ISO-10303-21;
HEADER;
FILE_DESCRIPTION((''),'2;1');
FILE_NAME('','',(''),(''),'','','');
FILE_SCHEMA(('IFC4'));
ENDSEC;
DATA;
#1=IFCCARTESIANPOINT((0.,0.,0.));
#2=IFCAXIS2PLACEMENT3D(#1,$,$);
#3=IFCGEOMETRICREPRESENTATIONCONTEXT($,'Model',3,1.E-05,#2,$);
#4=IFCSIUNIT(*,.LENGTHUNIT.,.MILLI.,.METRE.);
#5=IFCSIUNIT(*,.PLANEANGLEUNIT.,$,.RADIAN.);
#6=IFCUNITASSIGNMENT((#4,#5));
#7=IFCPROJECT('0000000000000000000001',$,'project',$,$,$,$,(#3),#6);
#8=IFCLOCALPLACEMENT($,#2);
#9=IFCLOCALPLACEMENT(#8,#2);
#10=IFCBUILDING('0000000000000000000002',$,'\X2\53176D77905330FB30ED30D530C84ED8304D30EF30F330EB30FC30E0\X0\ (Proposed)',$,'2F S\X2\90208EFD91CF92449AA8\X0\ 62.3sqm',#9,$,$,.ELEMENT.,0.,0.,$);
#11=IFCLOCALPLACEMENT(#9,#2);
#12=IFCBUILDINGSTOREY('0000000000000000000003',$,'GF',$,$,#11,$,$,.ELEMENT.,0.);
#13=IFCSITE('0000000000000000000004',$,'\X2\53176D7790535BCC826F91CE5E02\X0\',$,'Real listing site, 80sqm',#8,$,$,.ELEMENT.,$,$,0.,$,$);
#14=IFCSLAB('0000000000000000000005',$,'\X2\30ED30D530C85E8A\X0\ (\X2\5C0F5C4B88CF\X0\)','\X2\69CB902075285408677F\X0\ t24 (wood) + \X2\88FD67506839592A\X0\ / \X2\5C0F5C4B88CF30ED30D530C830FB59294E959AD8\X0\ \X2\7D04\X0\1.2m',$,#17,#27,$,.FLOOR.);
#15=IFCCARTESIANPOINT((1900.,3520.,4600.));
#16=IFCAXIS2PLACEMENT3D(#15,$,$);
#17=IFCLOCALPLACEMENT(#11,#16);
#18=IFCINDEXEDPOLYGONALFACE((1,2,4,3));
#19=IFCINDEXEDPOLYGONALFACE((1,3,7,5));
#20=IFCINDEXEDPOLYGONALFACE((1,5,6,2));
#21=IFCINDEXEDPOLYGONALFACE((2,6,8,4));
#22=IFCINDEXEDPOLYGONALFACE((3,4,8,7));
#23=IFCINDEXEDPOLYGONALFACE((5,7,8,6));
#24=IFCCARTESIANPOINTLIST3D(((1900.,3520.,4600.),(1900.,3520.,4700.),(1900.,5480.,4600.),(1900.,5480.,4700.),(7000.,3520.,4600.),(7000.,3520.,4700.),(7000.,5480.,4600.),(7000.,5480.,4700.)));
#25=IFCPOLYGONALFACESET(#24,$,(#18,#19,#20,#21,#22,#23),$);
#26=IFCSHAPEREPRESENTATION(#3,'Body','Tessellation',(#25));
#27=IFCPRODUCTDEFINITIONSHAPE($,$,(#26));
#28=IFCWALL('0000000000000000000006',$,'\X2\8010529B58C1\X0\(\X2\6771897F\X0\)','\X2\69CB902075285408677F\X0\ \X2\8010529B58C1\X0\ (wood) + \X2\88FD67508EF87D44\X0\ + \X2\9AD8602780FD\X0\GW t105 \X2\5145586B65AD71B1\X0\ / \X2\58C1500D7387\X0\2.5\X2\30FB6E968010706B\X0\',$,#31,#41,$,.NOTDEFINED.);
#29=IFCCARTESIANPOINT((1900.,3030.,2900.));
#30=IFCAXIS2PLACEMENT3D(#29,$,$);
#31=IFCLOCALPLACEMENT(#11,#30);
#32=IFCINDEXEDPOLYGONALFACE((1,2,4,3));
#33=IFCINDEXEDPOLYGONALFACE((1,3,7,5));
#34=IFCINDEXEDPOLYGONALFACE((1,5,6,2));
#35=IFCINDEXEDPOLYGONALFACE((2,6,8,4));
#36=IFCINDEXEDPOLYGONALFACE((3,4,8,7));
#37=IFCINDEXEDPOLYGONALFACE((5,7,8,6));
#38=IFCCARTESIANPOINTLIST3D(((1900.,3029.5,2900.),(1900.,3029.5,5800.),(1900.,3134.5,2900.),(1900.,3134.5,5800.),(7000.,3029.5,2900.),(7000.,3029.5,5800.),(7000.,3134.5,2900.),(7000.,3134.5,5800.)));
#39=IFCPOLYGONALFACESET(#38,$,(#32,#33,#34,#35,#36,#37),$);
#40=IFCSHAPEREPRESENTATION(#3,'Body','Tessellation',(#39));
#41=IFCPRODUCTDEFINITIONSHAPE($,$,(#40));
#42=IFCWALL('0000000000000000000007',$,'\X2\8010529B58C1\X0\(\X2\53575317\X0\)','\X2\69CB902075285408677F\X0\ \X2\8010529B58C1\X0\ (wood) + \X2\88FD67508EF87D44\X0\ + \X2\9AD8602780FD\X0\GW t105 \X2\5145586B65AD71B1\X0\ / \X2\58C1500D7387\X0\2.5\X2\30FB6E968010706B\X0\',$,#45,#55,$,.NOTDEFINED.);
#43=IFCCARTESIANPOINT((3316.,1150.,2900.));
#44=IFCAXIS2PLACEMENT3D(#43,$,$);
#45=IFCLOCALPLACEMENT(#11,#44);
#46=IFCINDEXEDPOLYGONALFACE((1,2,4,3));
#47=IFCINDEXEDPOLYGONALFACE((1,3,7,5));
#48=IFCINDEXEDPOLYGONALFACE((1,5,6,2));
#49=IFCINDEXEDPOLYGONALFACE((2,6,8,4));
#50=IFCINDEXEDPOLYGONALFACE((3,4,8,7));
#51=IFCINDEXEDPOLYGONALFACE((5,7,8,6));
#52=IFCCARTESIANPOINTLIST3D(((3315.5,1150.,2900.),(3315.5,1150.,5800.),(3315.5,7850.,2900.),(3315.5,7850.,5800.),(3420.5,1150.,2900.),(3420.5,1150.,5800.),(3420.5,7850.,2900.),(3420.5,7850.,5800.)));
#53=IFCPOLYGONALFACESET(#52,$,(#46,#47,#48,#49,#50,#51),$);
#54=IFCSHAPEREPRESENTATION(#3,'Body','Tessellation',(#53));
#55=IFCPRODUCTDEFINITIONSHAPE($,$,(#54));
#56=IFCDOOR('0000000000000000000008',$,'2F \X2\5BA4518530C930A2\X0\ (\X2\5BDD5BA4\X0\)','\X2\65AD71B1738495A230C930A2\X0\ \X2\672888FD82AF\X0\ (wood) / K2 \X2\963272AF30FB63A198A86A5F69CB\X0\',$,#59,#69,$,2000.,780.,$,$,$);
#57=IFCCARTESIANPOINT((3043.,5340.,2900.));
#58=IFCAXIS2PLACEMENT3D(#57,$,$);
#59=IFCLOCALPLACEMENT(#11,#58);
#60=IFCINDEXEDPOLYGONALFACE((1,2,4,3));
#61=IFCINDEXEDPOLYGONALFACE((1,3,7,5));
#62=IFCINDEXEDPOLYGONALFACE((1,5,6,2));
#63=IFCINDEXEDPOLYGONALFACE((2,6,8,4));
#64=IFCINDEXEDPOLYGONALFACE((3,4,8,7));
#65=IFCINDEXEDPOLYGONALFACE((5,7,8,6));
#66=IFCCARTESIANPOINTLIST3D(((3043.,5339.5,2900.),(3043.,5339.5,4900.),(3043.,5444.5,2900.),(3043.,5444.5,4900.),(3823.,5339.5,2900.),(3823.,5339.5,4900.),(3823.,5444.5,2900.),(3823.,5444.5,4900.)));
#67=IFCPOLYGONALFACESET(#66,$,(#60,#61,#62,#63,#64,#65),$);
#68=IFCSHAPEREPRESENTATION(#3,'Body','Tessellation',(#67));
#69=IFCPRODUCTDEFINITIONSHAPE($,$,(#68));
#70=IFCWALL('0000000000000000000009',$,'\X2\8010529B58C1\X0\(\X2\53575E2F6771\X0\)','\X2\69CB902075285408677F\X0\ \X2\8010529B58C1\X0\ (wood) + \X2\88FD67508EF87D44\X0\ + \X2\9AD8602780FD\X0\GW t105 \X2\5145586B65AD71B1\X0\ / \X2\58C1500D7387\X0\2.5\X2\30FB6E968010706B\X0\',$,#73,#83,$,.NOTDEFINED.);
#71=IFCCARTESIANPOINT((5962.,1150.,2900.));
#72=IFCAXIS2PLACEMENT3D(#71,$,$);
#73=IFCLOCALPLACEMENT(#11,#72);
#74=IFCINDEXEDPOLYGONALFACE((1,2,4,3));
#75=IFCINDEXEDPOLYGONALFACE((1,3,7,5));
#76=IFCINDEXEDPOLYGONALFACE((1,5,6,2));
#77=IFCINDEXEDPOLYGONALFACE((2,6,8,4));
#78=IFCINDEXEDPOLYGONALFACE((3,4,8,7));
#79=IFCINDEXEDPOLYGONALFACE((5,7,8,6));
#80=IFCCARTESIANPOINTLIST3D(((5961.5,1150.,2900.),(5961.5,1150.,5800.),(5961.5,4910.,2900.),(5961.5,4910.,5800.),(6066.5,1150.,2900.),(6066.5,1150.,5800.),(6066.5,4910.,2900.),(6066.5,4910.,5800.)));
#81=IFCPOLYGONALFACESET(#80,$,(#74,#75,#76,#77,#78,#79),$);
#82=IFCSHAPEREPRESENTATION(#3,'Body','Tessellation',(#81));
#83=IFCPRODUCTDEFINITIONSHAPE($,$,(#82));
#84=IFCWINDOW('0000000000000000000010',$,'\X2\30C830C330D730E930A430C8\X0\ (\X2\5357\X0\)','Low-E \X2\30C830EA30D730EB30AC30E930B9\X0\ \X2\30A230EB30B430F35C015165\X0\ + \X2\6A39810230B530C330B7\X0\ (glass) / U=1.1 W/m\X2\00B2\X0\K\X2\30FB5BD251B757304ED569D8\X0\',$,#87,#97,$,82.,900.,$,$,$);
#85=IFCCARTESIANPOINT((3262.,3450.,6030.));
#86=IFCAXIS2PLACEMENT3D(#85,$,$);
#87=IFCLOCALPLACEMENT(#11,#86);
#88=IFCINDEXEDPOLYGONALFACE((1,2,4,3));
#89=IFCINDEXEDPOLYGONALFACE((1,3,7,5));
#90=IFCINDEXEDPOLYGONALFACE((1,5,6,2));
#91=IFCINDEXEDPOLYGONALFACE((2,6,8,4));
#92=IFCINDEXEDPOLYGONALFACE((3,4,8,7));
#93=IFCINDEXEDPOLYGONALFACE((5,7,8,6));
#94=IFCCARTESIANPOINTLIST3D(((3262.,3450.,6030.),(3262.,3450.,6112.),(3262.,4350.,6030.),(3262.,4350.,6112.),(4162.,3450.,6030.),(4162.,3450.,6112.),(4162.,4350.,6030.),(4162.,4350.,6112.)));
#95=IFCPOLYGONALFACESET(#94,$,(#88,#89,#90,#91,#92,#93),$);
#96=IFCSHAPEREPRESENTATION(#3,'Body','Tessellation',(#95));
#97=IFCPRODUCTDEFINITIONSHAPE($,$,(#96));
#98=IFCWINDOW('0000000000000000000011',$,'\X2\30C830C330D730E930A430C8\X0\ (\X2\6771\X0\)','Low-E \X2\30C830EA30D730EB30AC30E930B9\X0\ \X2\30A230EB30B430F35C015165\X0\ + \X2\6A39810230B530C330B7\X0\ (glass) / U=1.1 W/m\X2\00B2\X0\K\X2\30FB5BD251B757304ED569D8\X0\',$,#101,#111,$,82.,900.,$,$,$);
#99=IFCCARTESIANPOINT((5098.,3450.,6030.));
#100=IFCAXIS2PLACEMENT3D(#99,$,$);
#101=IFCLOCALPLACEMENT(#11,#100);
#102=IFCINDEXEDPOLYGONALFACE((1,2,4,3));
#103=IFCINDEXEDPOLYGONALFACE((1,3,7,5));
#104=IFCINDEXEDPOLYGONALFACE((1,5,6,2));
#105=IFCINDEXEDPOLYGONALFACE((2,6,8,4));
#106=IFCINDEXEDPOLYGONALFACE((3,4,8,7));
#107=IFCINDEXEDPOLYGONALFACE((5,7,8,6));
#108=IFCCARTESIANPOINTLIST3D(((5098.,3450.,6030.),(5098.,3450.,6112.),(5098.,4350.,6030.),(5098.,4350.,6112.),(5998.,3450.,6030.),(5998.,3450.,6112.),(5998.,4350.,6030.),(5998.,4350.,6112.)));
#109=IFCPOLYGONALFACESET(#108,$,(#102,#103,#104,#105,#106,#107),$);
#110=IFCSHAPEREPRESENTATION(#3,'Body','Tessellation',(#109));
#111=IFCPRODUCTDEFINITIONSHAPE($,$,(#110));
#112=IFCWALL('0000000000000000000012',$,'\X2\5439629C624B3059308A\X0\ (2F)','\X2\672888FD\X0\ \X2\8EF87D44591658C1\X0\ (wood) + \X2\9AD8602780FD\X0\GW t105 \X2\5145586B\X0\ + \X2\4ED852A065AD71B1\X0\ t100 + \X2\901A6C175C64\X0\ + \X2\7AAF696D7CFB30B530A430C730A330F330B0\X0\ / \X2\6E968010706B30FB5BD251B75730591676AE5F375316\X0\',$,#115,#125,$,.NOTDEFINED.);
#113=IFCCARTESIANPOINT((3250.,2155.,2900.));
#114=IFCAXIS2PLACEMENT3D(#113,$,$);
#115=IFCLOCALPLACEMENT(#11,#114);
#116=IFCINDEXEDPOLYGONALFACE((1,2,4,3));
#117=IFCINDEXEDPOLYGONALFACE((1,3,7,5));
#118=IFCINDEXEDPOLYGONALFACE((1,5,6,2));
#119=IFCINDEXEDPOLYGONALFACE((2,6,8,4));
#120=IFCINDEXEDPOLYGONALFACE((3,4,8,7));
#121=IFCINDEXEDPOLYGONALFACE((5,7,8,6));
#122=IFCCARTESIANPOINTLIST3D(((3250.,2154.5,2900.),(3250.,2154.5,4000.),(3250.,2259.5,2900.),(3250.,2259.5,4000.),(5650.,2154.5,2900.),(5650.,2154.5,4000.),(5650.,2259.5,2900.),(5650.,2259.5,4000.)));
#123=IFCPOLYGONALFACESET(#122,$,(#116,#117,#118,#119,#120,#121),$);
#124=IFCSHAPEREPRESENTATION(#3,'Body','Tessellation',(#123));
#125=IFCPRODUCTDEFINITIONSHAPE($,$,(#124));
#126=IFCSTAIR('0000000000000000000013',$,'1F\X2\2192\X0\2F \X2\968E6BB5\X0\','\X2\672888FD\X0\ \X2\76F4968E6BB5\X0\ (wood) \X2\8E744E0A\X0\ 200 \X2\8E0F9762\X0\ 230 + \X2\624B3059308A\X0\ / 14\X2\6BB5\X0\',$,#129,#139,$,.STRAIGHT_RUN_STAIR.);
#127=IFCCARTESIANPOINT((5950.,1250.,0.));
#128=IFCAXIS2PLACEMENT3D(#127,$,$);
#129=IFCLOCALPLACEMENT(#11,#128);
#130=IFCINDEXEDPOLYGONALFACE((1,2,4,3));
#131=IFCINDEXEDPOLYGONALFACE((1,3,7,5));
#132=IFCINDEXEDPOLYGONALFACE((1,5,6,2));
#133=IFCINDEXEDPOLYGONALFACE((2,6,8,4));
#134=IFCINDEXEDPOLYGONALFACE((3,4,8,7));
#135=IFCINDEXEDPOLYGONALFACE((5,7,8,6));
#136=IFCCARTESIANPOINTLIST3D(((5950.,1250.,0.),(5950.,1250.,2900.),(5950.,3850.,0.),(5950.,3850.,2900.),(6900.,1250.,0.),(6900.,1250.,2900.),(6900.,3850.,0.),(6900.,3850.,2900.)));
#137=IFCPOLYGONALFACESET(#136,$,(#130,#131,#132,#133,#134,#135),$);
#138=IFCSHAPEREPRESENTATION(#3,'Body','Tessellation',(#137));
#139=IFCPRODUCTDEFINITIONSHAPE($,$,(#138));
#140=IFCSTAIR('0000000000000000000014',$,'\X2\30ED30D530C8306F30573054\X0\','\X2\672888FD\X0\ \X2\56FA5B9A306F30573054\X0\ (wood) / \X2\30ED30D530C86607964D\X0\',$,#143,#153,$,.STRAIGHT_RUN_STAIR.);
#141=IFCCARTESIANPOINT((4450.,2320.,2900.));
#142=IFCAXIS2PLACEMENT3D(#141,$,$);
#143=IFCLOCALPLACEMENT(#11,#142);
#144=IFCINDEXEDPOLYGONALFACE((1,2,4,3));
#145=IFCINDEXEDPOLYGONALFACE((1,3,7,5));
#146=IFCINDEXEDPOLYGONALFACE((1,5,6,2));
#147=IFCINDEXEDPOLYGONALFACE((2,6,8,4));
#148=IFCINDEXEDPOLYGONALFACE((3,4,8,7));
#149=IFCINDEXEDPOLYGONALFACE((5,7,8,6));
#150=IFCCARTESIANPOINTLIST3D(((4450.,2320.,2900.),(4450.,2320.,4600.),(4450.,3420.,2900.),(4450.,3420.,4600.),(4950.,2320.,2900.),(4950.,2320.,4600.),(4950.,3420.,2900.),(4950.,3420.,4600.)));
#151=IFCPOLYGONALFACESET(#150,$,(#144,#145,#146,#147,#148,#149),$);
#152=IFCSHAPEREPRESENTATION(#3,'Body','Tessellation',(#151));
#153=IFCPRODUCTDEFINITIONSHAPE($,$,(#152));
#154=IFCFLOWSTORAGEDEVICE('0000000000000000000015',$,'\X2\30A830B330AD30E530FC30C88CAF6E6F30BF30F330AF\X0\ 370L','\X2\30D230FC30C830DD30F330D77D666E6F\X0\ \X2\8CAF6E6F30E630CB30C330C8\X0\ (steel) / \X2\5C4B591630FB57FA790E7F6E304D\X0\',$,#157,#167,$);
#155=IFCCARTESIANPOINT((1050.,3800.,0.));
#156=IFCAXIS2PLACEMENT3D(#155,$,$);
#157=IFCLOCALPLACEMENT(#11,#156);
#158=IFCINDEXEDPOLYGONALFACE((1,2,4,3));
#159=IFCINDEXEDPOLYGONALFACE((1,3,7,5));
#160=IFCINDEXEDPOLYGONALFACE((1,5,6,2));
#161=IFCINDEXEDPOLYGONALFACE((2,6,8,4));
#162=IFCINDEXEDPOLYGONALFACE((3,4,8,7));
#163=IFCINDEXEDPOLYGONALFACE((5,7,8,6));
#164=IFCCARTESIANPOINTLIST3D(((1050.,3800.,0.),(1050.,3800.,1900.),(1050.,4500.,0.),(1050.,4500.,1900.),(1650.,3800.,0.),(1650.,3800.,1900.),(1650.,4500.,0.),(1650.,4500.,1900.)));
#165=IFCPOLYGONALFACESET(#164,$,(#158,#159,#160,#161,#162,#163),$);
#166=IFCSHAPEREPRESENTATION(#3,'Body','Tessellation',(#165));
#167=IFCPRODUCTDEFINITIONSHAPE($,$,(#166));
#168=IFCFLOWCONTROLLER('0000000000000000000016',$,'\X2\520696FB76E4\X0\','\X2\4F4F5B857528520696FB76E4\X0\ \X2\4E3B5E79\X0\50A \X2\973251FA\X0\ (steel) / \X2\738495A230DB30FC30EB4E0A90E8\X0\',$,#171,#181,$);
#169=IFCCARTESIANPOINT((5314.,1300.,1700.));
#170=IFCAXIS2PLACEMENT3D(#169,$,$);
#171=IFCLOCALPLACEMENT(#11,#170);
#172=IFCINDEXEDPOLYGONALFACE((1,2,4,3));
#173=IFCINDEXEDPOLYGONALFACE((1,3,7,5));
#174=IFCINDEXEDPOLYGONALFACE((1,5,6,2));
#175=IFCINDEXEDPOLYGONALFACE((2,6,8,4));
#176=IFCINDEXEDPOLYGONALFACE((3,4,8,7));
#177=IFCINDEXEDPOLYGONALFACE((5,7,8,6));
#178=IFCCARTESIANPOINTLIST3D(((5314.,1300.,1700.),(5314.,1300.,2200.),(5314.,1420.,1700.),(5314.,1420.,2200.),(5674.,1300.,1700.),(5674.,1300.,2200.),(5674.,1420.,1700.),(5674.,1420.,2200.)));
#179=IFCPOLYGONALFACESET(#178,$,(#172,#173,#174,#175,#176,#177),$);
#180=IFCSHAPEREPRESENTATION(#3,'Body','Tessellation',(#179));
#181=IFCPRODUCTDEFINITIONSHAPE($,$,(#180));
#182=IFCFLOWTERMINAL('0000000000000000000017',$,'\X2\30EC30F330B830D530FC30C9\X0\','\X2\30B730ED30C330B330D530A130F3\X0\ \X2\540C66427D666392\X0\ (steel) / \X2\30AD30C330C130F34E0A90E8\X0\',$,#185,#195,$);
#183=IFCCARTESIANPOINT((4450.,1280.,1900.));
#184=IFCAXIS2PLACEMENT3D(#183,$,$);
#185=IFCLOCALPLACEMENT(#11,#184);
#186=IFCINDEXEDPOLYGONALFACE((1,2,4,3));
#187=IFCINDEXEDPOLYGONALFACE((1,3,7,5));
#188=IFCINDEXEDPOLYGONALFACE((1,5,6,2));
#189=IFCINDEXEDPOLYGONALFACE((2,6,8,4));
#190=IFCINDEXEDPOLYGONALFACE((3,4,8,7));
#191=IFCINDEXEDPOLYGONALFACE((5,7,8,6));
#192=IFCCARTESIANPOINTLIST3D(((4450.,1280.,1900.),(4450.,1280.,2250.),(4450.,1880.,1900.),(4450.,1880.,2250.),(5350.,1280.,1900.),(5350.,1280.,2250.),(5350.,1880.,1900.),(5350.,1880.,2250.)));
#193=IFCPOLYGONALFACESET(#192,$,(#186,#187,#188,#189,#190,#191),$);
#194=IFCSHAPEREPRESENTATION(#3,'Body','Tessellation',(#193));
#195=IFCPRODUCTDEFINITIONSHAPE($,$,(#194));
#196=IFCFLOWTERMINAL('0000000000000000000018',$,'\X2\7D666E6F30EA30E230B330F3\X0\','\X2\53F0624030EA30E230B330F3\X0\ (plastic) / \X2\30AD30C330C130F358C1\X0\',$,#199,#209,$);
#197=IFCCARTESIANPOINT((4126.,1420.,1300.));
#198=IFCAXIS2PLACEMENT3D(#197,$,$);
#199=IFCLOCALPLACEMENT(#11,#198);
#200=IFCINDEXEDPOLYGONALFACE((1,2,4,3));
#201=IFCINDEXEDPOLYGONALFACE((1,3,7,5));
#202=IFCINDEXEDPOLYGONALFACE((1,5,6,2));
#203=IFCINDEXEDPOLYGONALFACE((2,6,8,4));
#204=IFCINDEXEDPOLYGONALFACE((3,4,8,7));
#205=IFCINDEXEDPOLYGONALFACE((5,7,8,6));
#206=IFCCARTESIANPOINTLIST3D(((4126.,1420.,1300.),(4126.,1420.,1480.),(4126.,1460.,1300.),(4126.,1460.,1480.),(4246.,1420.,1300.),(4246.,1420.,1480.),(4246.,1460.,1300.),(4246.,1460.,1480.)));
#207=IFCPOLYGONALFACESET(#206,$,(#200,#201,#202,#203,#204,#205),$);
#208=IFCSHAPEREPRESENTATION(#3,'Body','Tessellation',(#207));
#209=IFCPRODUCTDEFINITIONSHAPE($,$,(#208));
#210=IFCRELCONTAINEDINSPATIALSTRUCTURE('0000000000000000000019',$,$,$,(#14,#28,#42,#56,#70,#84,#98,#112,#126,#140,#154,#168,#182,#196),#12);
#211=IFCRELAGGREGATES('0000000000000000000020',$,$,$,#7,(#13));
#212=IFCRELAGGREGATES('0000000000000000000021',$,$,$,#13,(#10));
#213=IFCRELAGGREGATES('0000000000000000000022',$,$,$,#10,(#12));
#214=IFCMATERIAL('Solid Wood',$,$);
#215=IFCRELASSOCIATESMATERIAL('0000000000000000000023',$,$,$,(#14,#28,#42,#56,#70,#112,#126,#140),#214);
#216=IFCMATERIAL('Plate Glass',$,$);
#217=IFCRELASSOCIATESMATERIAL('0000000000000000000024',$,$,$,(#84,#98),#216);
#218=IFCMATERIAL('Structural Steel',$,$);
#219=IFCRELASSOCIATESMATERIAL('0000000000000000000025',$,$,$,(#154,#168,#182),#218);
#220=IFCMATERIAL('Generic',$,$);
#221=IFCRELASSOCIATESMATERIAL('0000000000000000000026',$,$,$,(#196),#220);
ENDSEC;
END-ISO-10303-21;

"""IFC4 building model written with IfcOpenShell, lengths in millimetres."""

from ifc_helpers import new_model, si_unit, frame, frame_2d, origin, place, context, project, spatial, rectangle, extrude, material, element, fill, save


model = new_model("IFC4")

# Units and contexts
model_context = context("Model", 3, precision=1e-05, world=origin())
ifc_project = project(units=[si_unit("LENGTHUNIT", "METRE", prefix="MILLI"), si_unit("PLANEANGLEUNIT", "RADIAN")], contexts=[model_context])

# Site, building, storey
site_placement = place(None, origin())
site = spatial("IfcSite", under=ifc_project, at=site_placement, Name="北海道富良野市", ObjectType="Real listing site, 80sqm", CompositionType="ELEMENT", RefElevation=0.0)
building_placement = place(site_placement, origin())
building = spatial("IfcBuilding", under=site, at=building_placement, Name="北海道・ロフト付きワンルーム (Proposed)", ObjectType="2F S造軽量鉄骨 62.3sqm", CompositionType="ELEMENT", ElevationOfRefHeight=0.0, ElevationOfTerrain=0.0)
storey_placement = place(building_placement, origin())
storey = spatial("IfcBuildingStorey", under=building, at=storey_placement, Name="GF", CompositionType="ELEMENT", Elevation=0.0)

# Shared definitions
ifc_material_1 = material(Name="Solid Wood")

# Slab
slab_placement = place(storey_placement, frame((1900.0, 3520.0, 4600.0)))
element("IfcSlab", 1, at=slab_placement, inside=storey, material=ifc_material_1, Name="ロフト床 (小屋裏)", Description="構造用合板 t24 (wood) + 製材根太 / 小屋裏ロフト・天井高 約1.2m", PredefinedType="FLOOR", context=model_context, shape_type="SweptSolid", body=[
    extrude(rectangle(XDim=5100.0, YDim=1960.0, at=frame_2d((2550.0, 980.0))), frame((1900.0, 3520.0, 4600.0)), (0.0, 0.0, 1.0), 100.0),
])

# Wall
wall_1_placement = place(storey_placement, frame((1900.0, 3030.0, 2900.0)))
element("IfcWall", 2, at=wall_1_placement, inside=storey, material=ifc_material_1, Name="耐力壁(東西)", Description="構造用合板 耐力壁 (wood) + 製材軸組 + 高性能GW t105 充填断熱 / 壁倍率2.5・準耐火", PredefinedType="NOTDEFINED", context=model_context, shape_type="SweptSolid", body=[
    extrude(rectangle(XDim=5100.0, YDim=105.0, at=frame_2d((2550.0, 52.0))), frame((1900.0, 3030.0, 2900.0)), (0.0, 0.0, 1.0), 2900.0),
])

# Wall, opening, door
wall_2_placement = place(storey_placement, frame((3316.0, 1150.0, 2900.0)))
wall_2 = element("IfcWall", 3, at=wall_2_placement, inside=storey, material=ifc_material_1, Name="耐力壁(南北)", Description="構造用合板 耐力壁 (wood) + 製材軸組 + 高性能GW t105 充填断熱 / 壁倍率2.5・準耐火", PredefinedType="NOTDEFINED", context=model_context, shape_type="SweptSolid", body=[
    extrude(rectangle(XDim=105.0, YDim=6700.0, at=frame_2d((52.0, 3350.0))), frame((3316.0, 1150.0, 2900.0)), (0.0, 0.0, 1.0), 2900.0),
])
opening_placement = place(storey_placement, frame((3043.0, 5340.0, 2900.0)))
opening = element("IfcOpeningElement", 4, at=opening_placement, cuts=wall_2, PredefinedType="NOTDEFINED", context=model_context, shape_type="SweptSolid", body=[
    extrude(rectangle(XDim=780.0, YDim=105.0, at=frame_2d((390.0, 52.0))), frame((3043.0, 5340.0, 2900.0)), (0.0, 0.0, 1.0), 2000.0),
])
door_placement = place(storey_placement, frame((3043.0, 5340.0, 2900.0)))
door = element("IfcDoor", 5, at=door_placement, inside=storey, material=ifc_material_1, Name="2F 室内ドア (寝室)", Description="断熱玄関ドア 木製芯 (wood) / K2 防犯・採風機構", OverallHeight=2000.0, OverallWidth=780.0, context=model_context, shape_type="SweptSolid", body=[
    extrude(rectangle(XDim=780.0, YDim=105.0, at=frame_2d((390.0, 52.0))), frame((3043.0, 5340.0, 2900.0)), (0.0, 0.0, 1.0), 2000.0),
])
fill(opening, door)

# Wall
wall_3_placement = place(storey_placement, frame((5962.0, 1150.0, 2900.0)))
element("IfcWall", 6, at=wall_3_placement, inside=storey, material=ifc_material_1, Name="耐力壁(南帯東)", Description="構造用合板 耐力壁 (wood) + 製材軸組 + 高性能GW t105 充填断熱 / 壁倍率2.5・準耐火", PredefinedType="NOTDEFINED", context=model_context, shape_type="SweptSolid", body=[
    extrude(rectangle(XDim=105.0, YDim=3760.0, at=frame_2d((52.0, 1880.0))), frame((5962.0, 1150.0, 2900.0)), (0.0, 0.0, 1.0), 2900.0),
])

# Windows
ifc_material_2 = material(Name="Plate Glass")
window_1_placement = place(storey_placement, frame((3262.0, 3450.0, 6030.0)))
element("IfcWindow", 7, at=window_1_placement, inside=storey, material=ifc_material_2, Name="トップライト (南)", Description="Low-E トリプルガラス アルゴン封入 + 樹脂サッシ (glass) / U=1.1 W/m²K・寒冷地仕様", OverallHeight=82.0, OverallWidth=900.0, context=model_context, shape_type="SweptSolid", body=[
    extrude(rectangle(XDim=900.0, YDim=900.0, at=frame_2d((450.0, 450.0))), frame((3262.0, 3450.0, 6030.0)), (0.0, 0.0, 1.0), 82.0),
])
window_2_placement = place(storey_placement, frame((5098.0, 3450.0, 6030.0)))
element("IfcWindow", 8, at=window_2_placement, inside=storey, material=ifc_material_2, Name="トップライト (東)", Description="Low-E トリプルガラス アルゴン封入 + 樹脂サッシ (glass) / U=1.1 W/m²K・寒冷地仕様", OverallHeight=82.0, OverallWidth=900.0, context=model_context, shape_type="SweptSolid", body=[
    extrude(rectangle(XDim=900.0, YDim=900.0, at=frame_2d((450.0, 450.0))), frame((5098.0, 3450.0, 6030.0)), (0.0, 0.0, 1.0), 82.0),
])

# Wall
wall_4_placement = place(storey_placement, frame((3250.0, 2155.0, 2900.0)))
element("IfcWall", 9, at=wall_4_placement, inside=storey, material=ifc_material_1, Name="吹抜手すり (2F)", Description="木製 軸組外壁 (wood) + 高性能GW t105 充填 + 付加断熱 t100 + 通気層 + 窯業系サイディング / 準耐火・寒冷地外皮強化", PredefinedType="NOTDEFINED", context=model_context, shape_type="SweptSolid", body=[
    extrude(rectangle(XDim=2400.0, YDim=105.0, at=frame_2d((1200.0, 52.0))), frame((3250.0, 2155.0, 2900.0)), (0.0, 0.0, 1.0), 1100.0),
])

# Stairs
stair_1_placement = place(storey_placement, frame((5950.0, 1250.0, 0.0)))
element("IfcStair", 10, at=stair_1_placement, inside=storey, material=ifc_material_1, Name="1F→2F 階段", Description="木製 直階段 (wood) 蹴上 200 踏面 230 + 手すり / 14段", PredefinedType="STRAIGHT_RUN_STAIR", context=model_context, shape_type="SweptSolid", body=[
    extrude(rectangle(XDim=950.0, YDim=2600.0, at=frame_2d((475.0, 1300.0))), frame((5950.0, 1250.0, 0.0)), (0.0, 0.0, 1.0), 2900.0),
])
stair_2_placement = place(storey_placement, frame((4450.0, 2320.0, 2900.0)))
element("IfcStair", 11, at=stair_2_placement, inside=storey, material=ifc_material_1, Name="ロフトはしご", Description="木製 固定はしご (wood) / ロフト昇降", PredefinedType="STRAIGHT_RUN_STAIR", context=model_context, shape_type="SweptSolid", body=[
    extrude(rectangle(XDim=500.0, YDim=1100.0, at=frame_2d((250.0, 550.0))), frame((4450.0, 2320.0, 2900.0)), (0.0, 0.0, 1.0), 1700.0),
])

# Flow storage device
ifc_material_3 = material(Name="Structural Steel")
flow_storage_device_placement = place(storey_placement, frame((1050.0, 3800.0, 0.0)))
element("IfcFlowStorageDevice", 12, at=flow_storage_device_placement, inside=storey, material=ifc_material_3, Name="エコキュート貯湯タンク 370L", Description="ヒートポンプ給湯 貯湯ユニット (steel) / 屋外・基礎置き", context=model_context, shape_type="SweptSolid", body=[
    extrude(rectangle(XDim=600.0, YDim=700.0, at=frame_2d((300.0, 350.0))), frame((1050.0, 3800.0, 0.0)), (0.0, 0.0, 1.0), 1900.0),
])

# Flow controller
flow_controller_placement = place(storey_placement, frame((5314.0, 1300.0, 1700.0)))
element("IfcFlowController", 13, at=flow_controller_placement, inside=storey, material=ifc_material_3, Name="分電盤", Description="住宅用分電盤 主幹50A 露出 (steel) / 玄関ホール上部", context=model_context, shape_type="SweptSolid", body=[
    extrude(rectangle(XDim=360.0, YDim=120.0, at=frame_2d((180.0, 60.0))), frame((5314.0, 1300.0, 1700.0)), (0.0, 0.0, 1.0), 500.0),
])

# Flow terminals
flow_terminal_1_placement = place(storey_placement, frame((4450.0, 1280.0, 1900.0)))
element("IfcFlowTerminal", 14, at=flow_terminal_1_placement, inside=storey, material=ifc_material_3, Name="レンジフード", Description="シロッコファン 同時給排 (steel) / キッチン上部", context=model_context, shape_type="SweptSolid", body=[
    extrude(rectangle(XDim=900.0, YDim=600.0, at=frame_2d((450.0, 300.0))), frame((4450.0, 1280.0, 1900.0)), (0.0, 0.0, 1.0), 350.0),
])
ifc_material_4 = material(Name="Generic")
flow_terminal_2_placement = place(storey_placement, frame((4126.0, 1420.0, 1300.0)))
element("IfcFlowTerminal", 15, at=flow_terminal_2_placement, inside=storey, material=ifc_material_4, Name="給湯リモコン", Description="台所リモコン (plastic) / キッチン壁", context=model_context, shape_type="SweptSolid", body=[
    extrude(rectangle(XDim=120.0, YDim=40.0, at=frame_2d((60.0, 20.0))), frame((4126.0, 1420.0, 1300.0)), (0.0, 0.0, 1.0), 180.0),
])

save(model, "model.ifc")
